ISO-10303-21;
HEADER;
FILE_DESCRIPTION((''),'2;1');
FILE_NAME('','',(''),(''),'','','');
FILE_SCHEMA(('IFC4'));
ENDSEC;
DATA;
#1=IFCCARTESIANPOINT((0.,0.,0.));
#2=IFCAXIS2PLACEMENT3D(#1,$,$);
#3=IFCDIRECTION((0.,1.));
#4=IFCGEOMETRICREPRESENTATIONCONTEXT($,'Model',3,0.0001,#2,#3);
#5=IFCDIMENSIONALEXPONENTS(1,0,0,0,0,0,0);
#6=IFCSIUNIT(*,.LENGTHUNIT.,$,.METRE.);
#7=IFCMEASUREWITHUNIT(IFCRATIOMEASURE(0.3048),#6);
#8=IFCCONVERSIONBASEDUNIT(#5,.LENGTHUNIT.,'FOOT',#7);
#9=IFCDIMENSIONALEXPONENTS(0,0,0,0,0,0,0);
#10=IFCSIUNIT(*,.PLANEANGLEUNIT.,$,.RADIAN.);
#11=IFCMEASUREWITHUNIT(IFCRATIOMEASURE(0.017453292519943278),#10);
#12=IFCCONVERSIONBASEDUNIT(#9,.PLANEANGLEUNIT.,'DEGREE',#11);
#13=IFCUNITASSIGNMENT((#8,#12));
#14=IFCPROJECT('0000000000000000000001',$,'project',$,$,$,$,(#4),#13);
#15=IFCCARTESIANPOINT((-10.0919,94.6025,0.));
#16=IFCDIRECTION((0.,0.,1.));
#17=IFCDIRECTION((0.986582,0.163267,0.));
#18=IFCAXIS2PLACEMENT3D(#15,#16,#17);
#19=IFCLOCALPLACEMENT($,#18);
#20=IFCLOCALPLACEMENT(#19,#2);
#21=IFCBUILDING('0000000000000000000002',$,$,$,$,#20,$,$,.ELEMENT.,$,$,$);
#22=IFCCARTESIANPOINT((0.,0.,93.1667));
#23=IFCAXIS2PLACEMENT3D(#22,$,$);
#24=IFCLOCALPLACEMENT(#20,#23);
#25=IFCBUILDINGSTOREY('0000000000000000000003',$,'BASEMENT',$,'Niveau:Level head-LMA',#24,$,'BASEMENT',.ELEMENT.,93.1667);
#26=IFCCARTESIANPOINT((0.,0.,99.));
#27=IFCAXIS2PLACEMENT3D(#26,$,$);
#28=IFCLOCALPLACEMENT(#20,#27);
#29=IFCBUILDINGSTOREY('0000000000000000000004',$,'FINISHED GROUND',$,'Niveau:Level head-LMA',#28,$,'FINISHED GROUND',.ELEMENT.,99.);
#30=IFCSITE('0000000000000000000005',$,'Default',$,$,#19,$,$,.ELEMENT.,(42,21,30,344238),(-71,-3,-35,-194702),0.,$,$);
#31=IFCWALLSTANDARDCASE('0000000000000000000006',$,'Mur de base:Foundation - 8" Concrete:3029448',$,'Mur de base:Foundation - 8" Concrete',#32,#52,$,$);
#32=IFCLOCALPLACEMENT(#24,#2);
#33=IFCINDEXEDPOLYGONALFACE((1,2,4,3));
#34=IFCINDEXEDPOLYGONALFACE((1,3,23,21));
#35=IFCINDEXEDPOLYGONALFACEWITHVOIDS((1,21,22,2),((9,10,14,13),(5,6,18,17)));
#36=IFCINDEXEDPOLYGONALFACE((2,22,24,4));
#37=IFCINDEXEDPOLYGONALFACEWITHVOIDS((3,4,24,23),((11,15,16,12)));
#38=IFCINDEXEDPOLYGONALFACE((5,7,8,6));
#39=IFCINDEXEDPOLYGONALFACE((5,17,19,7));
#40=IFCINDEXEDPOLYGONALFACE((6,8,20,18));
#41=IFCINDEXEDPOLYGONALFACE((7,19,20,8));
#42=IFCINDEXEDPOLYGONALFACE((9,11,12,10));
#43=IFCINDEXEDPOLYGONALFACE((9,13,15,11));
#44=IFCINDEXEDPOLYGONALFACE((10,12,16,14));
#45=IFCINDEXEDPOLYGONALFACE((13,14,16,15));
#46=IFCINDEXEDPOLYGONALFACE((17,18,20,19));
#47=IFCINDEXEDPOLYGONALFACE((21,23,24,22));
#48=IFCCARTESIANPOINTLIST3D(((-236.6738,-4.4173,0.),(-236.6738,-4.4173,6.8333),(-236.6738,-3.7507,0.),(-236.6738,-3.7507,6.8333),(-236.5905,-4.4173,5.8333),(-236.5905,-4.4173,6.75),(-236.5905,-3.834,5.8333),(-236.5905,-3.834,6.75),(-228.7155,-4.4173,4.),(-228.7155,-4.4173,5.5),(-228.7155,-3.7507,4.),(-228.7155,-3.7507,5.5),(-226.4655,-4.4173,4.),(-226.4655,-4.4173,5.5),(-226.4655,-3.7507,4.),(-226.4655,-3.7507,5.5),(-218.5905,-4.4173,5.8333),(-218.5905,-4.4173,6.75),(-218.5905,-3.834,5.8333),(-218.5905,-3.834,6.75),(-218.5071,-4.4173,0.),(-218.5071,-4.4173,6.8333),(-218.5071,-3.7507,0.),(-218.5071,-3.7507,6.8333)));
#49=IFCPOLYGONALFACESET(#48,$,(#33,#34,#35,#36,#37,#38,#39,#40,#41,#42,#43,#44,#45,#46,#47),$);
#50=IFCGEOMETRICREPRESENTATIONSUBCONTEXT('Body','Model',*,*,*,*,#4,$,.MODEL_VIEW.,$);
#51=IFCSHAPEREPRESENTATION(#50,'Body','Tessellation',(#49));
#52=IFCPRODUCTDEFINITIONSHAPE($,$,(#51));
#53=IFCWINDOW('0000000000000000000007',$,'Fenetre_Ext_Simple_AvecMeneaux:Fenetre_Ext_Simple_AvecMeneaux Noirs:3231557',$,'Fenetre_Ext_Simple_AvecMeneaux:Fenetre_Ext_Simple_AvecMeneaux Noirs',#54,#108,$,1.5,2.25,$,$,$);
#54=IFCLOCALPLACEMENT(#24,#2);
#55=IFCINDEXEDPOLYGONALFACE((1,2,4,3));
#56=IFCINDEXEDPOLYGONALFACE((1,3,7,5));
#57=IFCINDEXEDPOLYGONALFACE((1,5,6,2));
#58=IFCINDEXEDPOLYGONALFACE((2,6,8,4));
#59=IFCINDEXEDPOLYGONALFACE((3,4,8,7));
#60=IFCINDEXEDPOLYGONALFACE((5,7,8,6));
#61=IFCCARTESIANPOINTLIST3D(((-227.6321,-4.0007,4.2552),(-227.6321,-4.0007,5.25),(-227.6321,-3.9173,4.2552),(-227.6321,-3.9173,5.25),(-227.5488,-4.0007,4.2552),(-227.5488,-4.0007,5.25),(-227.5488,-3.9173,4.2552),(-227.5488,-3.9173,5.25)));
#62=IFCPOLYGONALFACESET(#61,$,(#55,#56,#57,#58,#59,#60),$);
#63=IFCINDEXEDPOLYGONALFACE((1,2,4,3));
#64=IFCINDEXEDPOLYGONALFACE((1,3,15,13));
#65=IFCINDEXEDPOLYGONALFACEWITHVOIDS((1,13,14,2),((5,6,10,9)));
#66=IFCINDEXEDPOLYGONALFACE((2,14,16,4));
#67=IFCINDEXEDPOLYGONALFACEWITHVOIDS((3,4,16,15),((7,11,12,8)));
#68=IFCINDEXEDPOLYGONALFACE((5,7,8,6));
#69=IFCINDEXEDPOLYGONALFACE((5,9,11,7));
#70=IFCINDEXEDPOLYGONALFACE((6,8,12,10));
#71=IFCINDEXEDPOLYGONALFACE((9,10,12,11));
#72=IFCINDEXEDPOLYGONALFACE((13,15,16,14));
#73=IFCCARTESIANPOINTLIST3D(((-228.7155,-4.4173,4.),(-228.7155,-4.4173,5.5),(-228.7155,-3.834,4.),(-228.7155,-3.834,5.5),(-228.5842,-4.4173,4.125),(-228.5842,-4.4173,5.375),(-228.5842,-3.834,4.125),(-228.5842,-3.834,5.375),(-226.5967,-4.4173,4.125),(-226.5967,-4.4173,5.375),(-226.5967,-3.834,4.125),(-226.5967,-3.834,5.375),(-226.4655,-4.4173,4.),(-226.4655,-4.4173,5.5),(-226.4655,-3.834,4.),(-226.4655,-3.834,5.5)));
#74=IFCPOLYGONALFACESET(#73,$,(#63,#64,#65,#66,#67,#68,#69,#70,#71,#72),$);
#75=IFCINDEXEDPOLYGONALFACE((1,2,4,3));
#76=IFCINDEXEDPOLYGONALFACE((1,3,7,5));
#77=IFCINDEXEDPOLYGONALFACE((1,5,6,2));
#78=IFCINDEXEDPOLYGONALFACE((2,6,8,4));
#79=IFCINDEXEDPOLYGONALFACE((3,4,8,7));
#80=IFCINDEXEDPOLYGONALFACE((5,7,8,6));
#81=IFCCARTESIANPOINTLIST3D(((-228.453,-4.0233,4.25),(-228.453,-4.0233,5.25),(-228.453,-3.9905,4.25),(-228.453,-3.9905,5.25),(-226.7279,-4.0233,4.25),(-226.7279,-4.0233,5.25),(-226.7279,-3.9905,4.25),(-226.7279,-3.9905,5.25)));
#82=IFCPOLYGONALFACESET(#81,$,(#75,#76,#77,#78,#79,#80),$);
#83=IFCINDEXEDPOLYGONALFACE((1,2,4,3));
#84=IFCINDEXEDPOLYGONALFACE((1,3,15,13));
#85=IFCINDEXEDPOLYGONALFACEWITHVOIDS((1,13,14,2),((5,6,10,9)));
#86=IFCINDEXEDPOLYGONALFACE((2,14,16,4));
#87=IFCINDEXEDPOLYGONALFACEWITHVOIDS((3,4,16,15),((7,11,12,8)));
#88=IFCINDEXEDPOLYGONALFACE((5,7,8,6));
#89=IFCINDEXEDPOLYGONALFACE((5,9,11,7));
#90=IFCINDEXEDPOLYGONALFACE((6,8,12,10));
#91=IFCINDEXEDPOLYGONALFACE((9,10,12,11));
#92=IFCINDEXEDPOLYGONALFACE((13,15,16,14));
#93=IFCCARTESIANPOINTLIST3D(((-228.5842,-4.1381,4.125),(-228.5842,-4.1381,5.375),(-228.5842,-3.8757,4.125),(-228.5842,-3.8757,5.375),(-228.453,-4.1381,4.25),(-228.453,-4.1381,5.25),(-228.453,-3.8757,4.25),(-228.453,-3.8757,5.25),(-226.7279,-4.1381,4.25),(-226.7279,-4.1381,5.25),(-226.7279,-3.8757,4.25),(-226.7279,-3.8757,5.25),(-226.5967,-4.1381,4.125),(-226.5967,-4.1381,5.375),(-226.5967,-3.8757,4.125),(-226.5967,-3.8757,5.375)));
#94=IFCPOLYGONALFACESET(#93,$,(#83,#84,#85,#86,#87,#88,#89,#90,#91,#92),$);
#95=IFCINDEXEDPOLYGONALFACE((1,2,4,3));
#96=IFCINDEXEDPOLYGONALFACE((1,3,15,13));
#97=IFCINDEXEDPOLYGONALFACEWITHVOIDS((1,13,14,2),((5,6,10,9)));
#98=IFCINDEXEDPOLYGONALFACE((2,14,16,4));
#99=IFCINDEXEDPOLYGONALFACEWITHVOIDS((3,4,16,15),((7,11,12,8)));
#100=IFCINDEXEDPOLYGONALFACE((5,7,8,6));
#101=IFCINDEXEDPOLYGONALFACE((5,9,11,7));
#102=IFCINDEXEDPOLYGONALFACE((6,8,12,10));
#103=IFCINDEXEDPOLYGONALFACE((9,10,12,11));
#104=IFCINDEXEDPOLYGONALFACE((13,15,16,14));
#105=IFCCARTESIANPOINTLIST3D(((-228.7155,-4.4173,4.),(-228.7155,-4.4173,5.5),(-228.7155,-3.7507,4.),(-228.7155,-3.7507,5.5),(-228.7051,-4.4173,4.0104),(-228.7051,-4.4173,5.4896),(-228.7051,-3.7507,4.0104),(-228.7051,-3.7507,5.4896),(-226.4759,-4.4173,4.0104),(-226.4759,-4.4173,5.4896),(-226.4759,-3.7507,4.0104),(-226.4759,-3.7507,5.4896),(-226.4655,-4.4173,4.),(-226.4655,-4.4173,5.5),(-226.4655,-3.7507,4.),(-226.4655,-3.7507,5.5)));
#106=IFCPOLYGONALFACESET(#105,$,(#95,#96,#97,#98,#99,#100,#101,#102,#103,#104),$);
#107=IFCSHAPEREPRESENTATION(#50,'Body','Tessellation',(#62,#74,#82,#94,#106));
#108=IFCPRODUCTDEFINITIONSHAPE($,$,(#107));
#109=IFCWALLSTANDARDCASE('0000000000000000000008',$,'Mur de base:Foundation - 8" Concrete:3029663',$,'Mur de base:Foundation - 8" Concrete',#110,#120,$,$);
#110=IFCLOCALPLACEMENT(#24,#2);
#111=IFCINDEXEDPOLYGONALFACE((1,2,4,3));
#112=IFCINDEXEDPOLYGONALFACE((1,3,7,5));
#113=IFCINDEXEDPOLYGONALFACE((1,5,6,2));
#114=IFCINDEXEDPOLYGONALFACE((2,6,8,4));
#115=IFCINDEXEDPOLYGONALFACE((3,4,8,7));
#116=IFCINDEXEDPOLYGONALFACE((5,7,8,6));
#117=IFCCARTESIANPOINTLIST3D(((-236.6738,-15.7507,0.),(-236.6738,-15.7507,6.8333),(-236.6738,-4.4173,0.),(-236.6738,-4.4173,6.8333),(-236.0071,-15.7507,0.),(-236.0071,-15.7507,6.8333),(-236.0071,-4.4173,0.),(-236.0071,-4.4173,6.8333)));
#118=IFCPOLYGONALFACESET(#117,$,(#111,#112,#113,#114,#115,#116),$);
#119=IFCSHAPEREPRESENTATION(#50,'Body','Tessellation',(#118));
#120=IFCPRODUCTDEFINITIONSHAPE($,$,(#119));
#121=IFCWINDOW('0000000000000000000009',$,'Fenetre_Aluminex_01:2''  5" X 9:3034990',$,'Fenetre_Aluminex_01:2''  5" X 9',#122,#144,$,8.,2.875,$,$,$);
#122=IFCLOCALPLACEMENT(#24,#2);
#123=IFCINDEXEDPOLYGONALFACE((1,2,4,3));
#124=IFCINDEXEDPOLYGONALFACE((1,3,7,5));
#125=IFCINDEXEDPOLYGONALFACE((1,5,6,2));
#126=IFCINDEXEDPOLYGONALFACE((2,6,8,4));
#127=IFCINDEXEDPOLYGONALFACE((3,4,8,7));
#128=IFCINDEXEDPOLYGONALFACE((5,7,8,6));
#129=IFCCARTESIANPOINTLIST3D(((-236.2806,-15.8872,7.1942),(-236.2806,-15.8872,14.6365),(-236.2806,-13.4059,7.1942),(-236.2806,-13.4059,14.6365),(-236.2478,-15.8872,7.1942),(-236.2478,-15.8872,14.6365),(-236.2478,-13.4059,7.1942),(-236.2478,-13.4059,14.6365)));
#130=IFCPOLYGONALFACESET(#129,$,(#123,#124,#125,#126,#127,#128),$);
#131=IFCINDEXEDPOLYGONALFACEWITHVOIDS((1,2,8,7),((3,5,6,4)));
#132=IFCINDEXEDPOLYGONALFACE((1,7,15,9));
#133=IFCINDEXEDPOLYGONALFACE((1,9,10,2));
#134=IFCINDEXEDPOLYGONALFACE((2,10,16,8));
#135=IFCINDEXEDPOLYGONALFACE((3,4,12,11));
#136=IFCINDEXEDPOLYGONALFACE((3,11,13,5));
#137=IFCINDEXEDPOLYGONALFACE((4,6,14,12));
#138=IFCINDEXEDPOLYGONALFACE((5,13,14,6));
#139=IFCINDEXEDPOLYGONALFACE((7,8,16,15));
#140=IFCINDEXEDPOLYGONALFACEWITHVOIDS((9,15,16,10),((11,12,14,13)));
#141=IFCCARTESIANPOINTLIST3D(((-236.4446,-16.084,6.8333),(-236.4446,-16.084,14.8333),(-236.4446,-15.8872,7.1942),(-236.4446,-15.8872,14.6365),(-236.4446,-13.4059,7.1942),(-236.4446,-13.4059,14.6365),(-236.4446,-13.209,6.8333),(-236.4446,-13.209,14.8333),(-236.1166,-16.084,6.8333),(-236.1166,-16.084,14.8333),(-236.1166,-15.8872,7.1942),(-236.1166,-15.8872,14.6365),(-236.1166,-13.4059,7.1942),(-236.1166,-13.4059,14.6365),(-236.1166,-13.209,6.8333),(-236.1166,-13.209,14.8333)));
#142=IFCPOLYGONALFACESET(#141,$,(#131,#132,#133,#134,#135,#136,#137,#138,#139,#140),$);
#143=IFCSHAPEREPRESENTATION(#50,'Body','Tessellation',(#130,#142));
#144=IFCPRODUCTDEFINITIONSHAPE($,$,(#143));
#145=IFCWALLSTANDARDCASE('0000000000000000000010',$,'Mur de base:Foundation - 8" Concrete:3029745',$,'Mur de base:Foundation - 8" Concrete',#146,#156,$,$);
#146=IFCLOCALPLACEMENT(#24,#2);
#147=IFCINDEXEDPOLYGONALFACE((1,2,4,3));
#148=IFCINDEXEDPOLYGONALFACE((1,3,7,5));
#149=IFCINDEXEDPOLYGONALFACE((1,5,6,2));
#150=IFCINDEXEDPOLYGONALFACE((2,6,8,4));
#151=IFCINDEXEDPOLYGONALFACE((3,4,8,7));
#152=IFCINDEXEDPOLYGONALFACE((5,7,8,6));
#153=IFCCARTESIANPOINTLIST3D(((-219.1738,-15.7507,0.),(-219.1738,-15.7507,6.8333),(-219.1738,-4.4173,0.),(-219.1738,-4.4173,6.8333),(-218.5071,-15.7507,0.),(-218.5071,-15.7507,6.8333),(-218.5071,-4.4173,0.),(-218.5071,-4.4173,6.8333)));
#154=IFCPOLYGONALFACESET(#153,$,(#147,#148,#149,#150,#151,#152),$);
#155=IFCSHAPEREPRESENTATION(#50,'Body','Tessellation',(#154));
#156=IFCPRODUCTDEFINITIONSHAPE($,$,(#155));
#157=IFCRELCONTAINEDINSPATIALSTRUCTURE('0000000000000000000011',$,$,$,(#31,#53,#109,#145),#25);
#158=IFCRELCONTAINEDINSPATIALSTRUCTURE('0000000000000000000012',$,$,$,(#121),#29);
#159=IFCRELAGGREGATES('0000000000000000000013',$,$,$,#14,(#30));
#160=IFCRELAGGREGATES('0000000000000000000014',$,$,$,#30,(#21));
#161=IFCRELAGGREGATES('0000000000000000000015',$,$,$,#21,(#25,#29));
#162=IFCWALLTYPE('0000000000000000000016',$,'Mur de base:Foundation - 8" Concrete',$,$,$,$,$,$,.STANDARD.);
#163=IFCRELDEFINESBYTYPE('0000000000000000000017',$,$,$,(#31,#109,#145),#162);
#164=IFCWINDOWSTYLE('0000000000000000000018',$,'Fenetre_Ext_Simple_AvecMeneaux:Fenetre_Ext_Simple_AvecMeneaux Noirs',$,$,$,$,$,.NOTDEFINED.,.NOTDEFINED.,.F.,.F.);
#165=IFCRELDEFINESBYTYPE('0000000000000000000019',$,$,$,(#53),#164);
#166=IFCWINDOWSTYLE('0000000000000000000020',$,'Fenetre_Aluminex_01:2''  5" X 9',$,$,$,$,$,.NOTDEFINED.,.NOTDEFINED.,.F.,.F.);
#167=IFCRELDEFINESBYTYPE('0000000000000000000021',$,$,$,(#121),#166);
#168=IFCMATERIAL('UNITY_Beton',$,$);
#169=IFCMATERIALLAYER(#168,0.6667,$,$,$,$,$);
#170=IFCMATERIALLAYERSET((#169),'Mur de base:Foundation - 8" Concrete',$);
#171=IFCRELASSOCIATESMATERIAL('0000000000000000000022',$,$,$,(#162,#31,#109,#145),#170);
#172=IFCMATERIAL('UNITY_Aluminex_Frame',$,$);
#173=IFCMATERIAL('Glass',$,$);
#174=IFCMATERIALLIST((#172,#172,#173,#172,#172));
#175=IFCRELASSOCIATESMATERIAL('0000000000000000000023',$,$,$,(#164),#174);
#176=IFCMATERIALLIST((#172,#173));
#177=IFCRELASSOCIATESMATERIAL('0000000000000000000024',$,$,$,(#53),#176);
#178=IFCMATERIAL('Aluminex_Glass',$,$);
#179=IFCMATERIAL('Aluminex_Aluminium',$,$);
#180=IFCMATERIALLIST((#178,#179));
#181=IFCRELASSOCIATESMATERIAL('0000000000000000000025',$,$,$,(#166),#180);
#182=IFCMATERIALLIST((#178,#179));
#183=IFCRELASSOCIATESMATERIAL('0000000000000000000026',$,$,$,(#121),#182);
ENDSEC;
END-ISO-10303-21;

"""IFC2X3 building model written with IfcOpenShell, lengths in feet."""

from ifc_helpers import new_model, entity, si_unit, converted_unit, direction, frame, frame_2d, origin, place, context, subcontext, project, spatial, polyline, rectangle, outline, extrude, source, transform, mapped, material, material_list, layer, layer_set, layer_usage, type_object, type_shapes, element, fill, save


model = new_model("IFC2X3")

# Units and contexts
model_context = context("Model", 3, precision=0.0001, world=origin(), true_north=direction((0.0, 1.0)))
body_context = subcontext(model_context, "Body", "Model", "MODEL_VIEW")
ifc_project = project(units=[converted_unit("LENGTHUNIT", "FOOT", entity("IfcRatioMeasure", 0.3048), si_unit("LENGTHUNIT", "METRE"), dimensions=[1, 0, 0, 0, 0, 0, 0]), converted_unit("PLANEANGLEUNIT", "DEGREE", entity("IfcRatioMeasure", 0.017453292519943278), si_unit("PLANEANGLEUNIT", "RADIAN"), dimensions=[0, 0, 0, 0, 0, 0, 0])], contexts=[model_context])

# Site, building, storey
site_placement = place(None, frame((-10.0919, 94.6025, 0.0), z_axis=(0.0, 0.0, 1.0), x_axis=(0.986582, 0.163267, 0.0)))
site = spatial("IfcSite", under=ifc_project, at=site_placement, Name="Default", CompositionType="ELEMENT", RefLatitude=(42, 21, 30, 344238), RefLongitude=(-71, -3, -35, -194702), RefElevation=0.0)
building_placement = place(site_placement, origin())
building = spatial("IfcBuilding", under=site, at=building_placement, CompositionType="ELEMENT")
storey_1_placement = place(building_placement, frame((0.0, 0.0, 93.1667)))
storey_1 = spatial("IfcBuildingStorey", under=building, at=storey_1_placement, Name="BASEMENT", ObjectType="Niveau:Level head-LMA", LongName="BASEMENT", CompositionType="ELEMENT", Elevation=93.1667)

# Wall, openings, window
ifc_material_1 = material(Name="UNITY_Beton")
ifc_layer_1 = layer(ifc_material_1, 0.6667)
ifc_layer_set_1 = layer_set([ifc_layer_1], Name="Mur de base:Foundation - 8\" Concrete")
ifc_layer_usage_1 = layer_usage(ifc_layer_set_1, "AXIS2", "POSITIVE", -0.3333)
wall_type = type_object("IfcWallType", Name="Mur de base:Foundation - 8\" Concrete", PredefinedType="STANDARD", material=ifc_layer_set_1)
wall_1_placement = place(storey_1_placement, frame((-218.5071, -4.084, 0.0), z_axis=(0.0, 0.0, 1.0), x_axis=(-1.0, 0.0, 0.0)))
wall_1 = element("IfcWallStandardCase", 1, at=wall_1_placement, inside=storey_1, type_object=wall_type, material=ifc_layer_usage_1, Name="Mur de base:Foundation - 8\" Concrete:3029448", ObjectType="Mur de base:Foundation - 8\" Concrete", context=body_context, shape_type="SweptSolid", body=[
    extrude(rectangle(XDim=18.1667, YDim=0.6667, at=frame_2d((9.0833, 0.0), x_axis=(-1.0, 0.0))), origin(), (0.0, 0.0, 1.0), 6.8333),
])
opening_1_placement = place(storey_1_placement, frame((-218.5071, -4.084, 0.0), z_axis=(0.0, 0.0, 1.0), x_axis=(-1.0, 0.0, 0.0)))
element("IfcOpeningElement", 2, at=opening_1_placement, cuts=wall_1, ObjectType="Opening", context=body_context, shape_type="SweptSolid", body=[
    extrude(rectangle(XDim=18.0, YDim=0.5833, at=frame_2d((0.0, 0.0), x_axis=(1.0, 0.0))), frame((9.0834, 0.0417, 5.8333)), (0.0, 0.0, 1.0), 0.9167),
])
opening_2_placement = place(wall_1_placement, frame((10.2083, 0.3333, 4.0)))
opening_2 = element("IfcOpeningElement", 3, at=opening_2_placement, cuts=wall_1, ObjectType="Opening", context=body_context, shape_type="SweptSolid", body=[
    extrude(rectangle(XDim=1.5, YDim=2.25, at=frame_2d((0.75, 1.125), x_axis=(1.0, 0.0))), frame((0.0, 0.0, 0.0), z_axis=(0.0, -1.0, 0.0), x_axis=(0.0, 0.0, 1.0)), (0.0, 0.0, 1.0), 0.6667),
])
ifc_material_2 = material(Name="UNITY_Aluminex_Frame")
ifc_material_3 = material(Name="Glass")
ifc_material_list_1 = material_list([ifc_material_2, ifc_material_3])
ifc_material_list_2 = material_list([ifc_material_2, ifc_material_2, ifc_material_3, ifc_material_2, ifc_material_2])
window_style_1 = type_object("IfcWindowStyle", Name="Fenetre_Ext_Simple_AvecMeneaux:Fenetre_Ext_Simple_AvecMeneaux Noirs", ConstructionType="NOTDEFINED", OperationType="NOTDEFINED", ParameterTakesPrecedence=False, Sizeable=False, material=ifc_material_list_2)
shared_shape_1 = source(origin(), body_context, "Body", "SweptSolid", [
    extrude(rectangle(XDim=0.0833, YDim=0.0833, at=frame_2d((0.0, 0.0), x_axis=(1.0, 0.0))), frame((1.125, 0.4583, 0.2552), z_axis=(0.0, 0.0, 1.0), x_axis=(0.0, -1.0, 0.0)), (0.0, 0.0, 1.0), 0.9948),
    extrude(outline(polyline([(-0.75, -1.125), (0.75, -1.125), (0.75, 1.125), (-0.75, 1.125), (-0.75, -1.125)]), holes=[polyline([(-0.625, 0.9938), (0.625, 0.9938), (0.625, -0.9938), (-0.625, -0.9938), (-0.625, 0.9938)])]), frame((1.125, 0.0, 0.75), z_axis=(0.0, 1.0, 0.0), x_axis=(0.0, 0.0, -1.0)), (0.0, 0.0, 1.0), 0.5833),
    extrude(rectangle(XDim=0.0328, YDim=1.7251, at=frame_2d((0.0, 0.0), x_axis=(1.0, 0.0))), frame((1.125, 0.4104, 0.25), z_axis=(0.0, 0.0, 1.0), x_axis=(0.0, 1.0, 0.0)), (0.0, 0.0, 1.0), 1.0),
    extrude(outline(polyline([(-0.9938, -0.625), (0.9938, -0.625), (0.9938, 0.625), (-0.9938, 0.625), (-0.9938, -0.625)]), holes=[polyline([(-0.8625, -0.5), (-0.8625, 0.5), (0.8625, 0.5), (0.8625, -0.5), (-0.8625, -0.5)])]), frame((1.125, 0.2792, 0.75), z_axis=(0.0, 1.0, 0.0), x_axis=(1.0, 0.0, 0.0)), (0.0, 0.0, 1.0), 0.2625),
    extrude(outline(polyline([(-1.125, -0.75), (1.125, -0.75), (1.125, 0.75), (-1.125, 0.75), (-1.125, -0.75)]), holes=[polyline([(1.1146, -0.7396), (-1.1146, -0.7396), (-1.1146, 0.7396), (1.1146, 0.7396), (1.1146, -0.7396)])]), frame((1.125, 0.0, 0.75), z_axis=(0.0, 1.0, 0.0), x_axis=(1.0, 0.0, 0.0)), (0.0, 0.0, 1.0), 0.6667),
])
type_shapes(window_style_1, [shared_shape_1])
window_1_placement = place(opening_2_placement, frame((0.0, 0.0, 0.0), z_axis=(0.0, 0.0, 1.0), x_axis=(-1.0, 0.0, 0.0)))
window_1 = element("IfcWindow", 4, at=window_1_placement, inside=storey_1, type_object=window_style_1, material=ifc_material_list_1, Name="Fenetre_Ext_Simple_AvecMeneaux:Fenetre_Ext_Simple_AvecMeneaux Noirs:3231557", ObjectType="Fenetre_Ext_Simple_AvecMeneaux:Fenetre_Ext_Simple_AvecMeneaux Noirs", OverallHeight=1.5, OverallWidth=2.25, context=body_context, shape_type="MappedRepresentation", body=[
    mapped(shared_shape_1, transform((0.0, 0.0, 0.0), scale=1.0)),
])
fill(opening_2, window_1)

# Wall, opening
ifc_layer_usage_2 = layer_usage(ifc_layer_set_1, "AXIS2", "NEGATIVE", 0.3333)
wall_2_placement = place(storey_1_placement, frame((-236.3405, -15.7507, 0.0), z_axis=(0.0, 0.0, 1.0), x_axis=(0.0, 1.0, 0.0)))
wall_2 = element("IfcWallStandardCase", 5, at=wall_2_placement, inside=storey_1, type_object=wall_type, material=ifc_layer_usage_2, Name="Mur de base:Foundation - 8\" Concrete:3029663", ObjectType="Mur de base:Foundation - 8\" Concrete", context=body_context, shape_type="SweptSolid", body=[
    extrude(rectangle(XDim=11.3333, YDim=0.6667, at=frame_2d((5.6667, 0.0), x_axis=(-1.0, 0.0))), origin(), (0.0, 0.0, 1.0), 6.8333),
])
opening_3_placement = place(wall_2_placement, frame((-0.3333, -0.3333, 6.8333)))
opening_3 = element("IfcOpeningElement", 6, at=opening_3_placement, cuts=wall_2, ObjectType="Opening", context=body_context, shape_type="SweptSolid", body=[
    extrude(rectangle(XDim=8.0, YDim=2.875, at=frame_2d((4.0, 1.4375), x_axis=(1.0, 0.0))), frame((0.0, 0.0, 0.0), z_axis=(0.0, 1.0, 0.0), x_axis=(0.0, 0.0, 1.0)), (0.0, 0.0, 1.0), 0.6667),
])

# Shared definitions
storey_2_placement = place(building_placement, frame((0.0, 0.0, 99.0)))
storey_2 = spatial("IfcBuildingStorey", under=building, at=storey_2_placement, Name="FINISHED GROUND", ObjectType="Niveau:Level head-LMA", LongName="FINISHED GROUND", CompositionType="ELEMENT", Elevation=99.0)

# Window
ifc_material_4 = material(Name="Aluminex_Glass")
ifc_material_5 = material(Name="Aluminex_Aluminium")
ifc_material_list_3 = material_list([ifc_material_4, ifc_material_5])
ifc_material_list_4 = material_list([ifc_material_4, ifc_material_5])
window_style_2 = type_object("IfcWindowStyle", Name="Fenetre_Aluminex_01:2'  5\" X 9", ConstructionType="NOTDEFINED", OperationType="NOTDEFINED", ParameterTakesPrecedence=False, Sizeable=False, material=ifc_material_list_4)
shared_shape_2 = source(origin(), body_context, "Body", "SweptSolid", [
    extrude(rectangle(XDim=0.0328, YDim=2.4813, at=frame_2d((0.0, 0.0), x_axis=(1.0, 0.0))), frame((1.4375, 0.2571, 0.3609), z_axis=(0.0, 0.0, 1.0), x_axis=(0.0, 1.0, 0.0)), (0.0, 0.0, 1.0), 7.4423),
    extrude(outline(polyline([(-1.4375, -4.0), (1.4375, -4.0), (1.4375, 4.0), (-1.4375, 4.0), (-1.4375, -4.0)]), holes=[polyline([(-1.2406, -3.8031), (-1.2406, 3.6391), (1.2406, 3.6391), (1.2406, -3.8031), (-1.2406, -3.8031)])]), frame((1.4375, 0.1094, 4.0), z_axis=(0.0, 1.0, 0.0), x_axis=(1.0, 0.0, 0.0)), (0.0, 0.0, 1.0), 0.3281),
])
type_shapes(window_style_2, [shared_shape_2])
window_2_placement = place(opening_3_placement, origin())
window_2 = element("IfcWindow", 7, at=window_2_placement, inside=storey_2, type_object=window_style_2, material=ifc_material_list_3, Name="Fenetre_Aluminex_01:2'  5\" X 9:3034990", ObjectType="Fenetre_Aluminex_01:2'  5\" X 9", OverallHeight=8.0, OverallWidth=2.875, context=body_context, shape_type="MappedRepresentation", body=[
    mapped(shared_shape_2, transform((0.0, 0.0, 0.0), scale=1.0)),
])
fill(opening_3, window_2)

# Wall
ifc_layer_usage_3 = layer_usage(ifc_layer_set_1, "AXIS2", "POSITIVE", -0.3333)
wall_3_placement = place(storey_1_placement, frame((-218.8405, -15.7507, 0.0), z_axis=(0.0, 0.0, 1.0), x_axis=(0.0, 1.0, 0.0)))
element("IfcWallStandardCase", 8, at=wall_3_placement, inside=storey_1, type_object=wall_type, material=ifc_layer_usage_3, Name="Mur de base:Foundation - 8\" Concrete:3029745", ObjectType="Mur de base:Foundation - 8\" Concrete", context=body_context, shape_type="SweptSolid", body=[
    extrude(rectangle(XDim=11.3333, YDim=0.6667, at=frame_2d((5.6667, 0.0), x_axis=(-1.0, 0.0))), origin(), (0.0, 0.0, 1.0), 6.8333),
])

save(model, "model.ifc")
